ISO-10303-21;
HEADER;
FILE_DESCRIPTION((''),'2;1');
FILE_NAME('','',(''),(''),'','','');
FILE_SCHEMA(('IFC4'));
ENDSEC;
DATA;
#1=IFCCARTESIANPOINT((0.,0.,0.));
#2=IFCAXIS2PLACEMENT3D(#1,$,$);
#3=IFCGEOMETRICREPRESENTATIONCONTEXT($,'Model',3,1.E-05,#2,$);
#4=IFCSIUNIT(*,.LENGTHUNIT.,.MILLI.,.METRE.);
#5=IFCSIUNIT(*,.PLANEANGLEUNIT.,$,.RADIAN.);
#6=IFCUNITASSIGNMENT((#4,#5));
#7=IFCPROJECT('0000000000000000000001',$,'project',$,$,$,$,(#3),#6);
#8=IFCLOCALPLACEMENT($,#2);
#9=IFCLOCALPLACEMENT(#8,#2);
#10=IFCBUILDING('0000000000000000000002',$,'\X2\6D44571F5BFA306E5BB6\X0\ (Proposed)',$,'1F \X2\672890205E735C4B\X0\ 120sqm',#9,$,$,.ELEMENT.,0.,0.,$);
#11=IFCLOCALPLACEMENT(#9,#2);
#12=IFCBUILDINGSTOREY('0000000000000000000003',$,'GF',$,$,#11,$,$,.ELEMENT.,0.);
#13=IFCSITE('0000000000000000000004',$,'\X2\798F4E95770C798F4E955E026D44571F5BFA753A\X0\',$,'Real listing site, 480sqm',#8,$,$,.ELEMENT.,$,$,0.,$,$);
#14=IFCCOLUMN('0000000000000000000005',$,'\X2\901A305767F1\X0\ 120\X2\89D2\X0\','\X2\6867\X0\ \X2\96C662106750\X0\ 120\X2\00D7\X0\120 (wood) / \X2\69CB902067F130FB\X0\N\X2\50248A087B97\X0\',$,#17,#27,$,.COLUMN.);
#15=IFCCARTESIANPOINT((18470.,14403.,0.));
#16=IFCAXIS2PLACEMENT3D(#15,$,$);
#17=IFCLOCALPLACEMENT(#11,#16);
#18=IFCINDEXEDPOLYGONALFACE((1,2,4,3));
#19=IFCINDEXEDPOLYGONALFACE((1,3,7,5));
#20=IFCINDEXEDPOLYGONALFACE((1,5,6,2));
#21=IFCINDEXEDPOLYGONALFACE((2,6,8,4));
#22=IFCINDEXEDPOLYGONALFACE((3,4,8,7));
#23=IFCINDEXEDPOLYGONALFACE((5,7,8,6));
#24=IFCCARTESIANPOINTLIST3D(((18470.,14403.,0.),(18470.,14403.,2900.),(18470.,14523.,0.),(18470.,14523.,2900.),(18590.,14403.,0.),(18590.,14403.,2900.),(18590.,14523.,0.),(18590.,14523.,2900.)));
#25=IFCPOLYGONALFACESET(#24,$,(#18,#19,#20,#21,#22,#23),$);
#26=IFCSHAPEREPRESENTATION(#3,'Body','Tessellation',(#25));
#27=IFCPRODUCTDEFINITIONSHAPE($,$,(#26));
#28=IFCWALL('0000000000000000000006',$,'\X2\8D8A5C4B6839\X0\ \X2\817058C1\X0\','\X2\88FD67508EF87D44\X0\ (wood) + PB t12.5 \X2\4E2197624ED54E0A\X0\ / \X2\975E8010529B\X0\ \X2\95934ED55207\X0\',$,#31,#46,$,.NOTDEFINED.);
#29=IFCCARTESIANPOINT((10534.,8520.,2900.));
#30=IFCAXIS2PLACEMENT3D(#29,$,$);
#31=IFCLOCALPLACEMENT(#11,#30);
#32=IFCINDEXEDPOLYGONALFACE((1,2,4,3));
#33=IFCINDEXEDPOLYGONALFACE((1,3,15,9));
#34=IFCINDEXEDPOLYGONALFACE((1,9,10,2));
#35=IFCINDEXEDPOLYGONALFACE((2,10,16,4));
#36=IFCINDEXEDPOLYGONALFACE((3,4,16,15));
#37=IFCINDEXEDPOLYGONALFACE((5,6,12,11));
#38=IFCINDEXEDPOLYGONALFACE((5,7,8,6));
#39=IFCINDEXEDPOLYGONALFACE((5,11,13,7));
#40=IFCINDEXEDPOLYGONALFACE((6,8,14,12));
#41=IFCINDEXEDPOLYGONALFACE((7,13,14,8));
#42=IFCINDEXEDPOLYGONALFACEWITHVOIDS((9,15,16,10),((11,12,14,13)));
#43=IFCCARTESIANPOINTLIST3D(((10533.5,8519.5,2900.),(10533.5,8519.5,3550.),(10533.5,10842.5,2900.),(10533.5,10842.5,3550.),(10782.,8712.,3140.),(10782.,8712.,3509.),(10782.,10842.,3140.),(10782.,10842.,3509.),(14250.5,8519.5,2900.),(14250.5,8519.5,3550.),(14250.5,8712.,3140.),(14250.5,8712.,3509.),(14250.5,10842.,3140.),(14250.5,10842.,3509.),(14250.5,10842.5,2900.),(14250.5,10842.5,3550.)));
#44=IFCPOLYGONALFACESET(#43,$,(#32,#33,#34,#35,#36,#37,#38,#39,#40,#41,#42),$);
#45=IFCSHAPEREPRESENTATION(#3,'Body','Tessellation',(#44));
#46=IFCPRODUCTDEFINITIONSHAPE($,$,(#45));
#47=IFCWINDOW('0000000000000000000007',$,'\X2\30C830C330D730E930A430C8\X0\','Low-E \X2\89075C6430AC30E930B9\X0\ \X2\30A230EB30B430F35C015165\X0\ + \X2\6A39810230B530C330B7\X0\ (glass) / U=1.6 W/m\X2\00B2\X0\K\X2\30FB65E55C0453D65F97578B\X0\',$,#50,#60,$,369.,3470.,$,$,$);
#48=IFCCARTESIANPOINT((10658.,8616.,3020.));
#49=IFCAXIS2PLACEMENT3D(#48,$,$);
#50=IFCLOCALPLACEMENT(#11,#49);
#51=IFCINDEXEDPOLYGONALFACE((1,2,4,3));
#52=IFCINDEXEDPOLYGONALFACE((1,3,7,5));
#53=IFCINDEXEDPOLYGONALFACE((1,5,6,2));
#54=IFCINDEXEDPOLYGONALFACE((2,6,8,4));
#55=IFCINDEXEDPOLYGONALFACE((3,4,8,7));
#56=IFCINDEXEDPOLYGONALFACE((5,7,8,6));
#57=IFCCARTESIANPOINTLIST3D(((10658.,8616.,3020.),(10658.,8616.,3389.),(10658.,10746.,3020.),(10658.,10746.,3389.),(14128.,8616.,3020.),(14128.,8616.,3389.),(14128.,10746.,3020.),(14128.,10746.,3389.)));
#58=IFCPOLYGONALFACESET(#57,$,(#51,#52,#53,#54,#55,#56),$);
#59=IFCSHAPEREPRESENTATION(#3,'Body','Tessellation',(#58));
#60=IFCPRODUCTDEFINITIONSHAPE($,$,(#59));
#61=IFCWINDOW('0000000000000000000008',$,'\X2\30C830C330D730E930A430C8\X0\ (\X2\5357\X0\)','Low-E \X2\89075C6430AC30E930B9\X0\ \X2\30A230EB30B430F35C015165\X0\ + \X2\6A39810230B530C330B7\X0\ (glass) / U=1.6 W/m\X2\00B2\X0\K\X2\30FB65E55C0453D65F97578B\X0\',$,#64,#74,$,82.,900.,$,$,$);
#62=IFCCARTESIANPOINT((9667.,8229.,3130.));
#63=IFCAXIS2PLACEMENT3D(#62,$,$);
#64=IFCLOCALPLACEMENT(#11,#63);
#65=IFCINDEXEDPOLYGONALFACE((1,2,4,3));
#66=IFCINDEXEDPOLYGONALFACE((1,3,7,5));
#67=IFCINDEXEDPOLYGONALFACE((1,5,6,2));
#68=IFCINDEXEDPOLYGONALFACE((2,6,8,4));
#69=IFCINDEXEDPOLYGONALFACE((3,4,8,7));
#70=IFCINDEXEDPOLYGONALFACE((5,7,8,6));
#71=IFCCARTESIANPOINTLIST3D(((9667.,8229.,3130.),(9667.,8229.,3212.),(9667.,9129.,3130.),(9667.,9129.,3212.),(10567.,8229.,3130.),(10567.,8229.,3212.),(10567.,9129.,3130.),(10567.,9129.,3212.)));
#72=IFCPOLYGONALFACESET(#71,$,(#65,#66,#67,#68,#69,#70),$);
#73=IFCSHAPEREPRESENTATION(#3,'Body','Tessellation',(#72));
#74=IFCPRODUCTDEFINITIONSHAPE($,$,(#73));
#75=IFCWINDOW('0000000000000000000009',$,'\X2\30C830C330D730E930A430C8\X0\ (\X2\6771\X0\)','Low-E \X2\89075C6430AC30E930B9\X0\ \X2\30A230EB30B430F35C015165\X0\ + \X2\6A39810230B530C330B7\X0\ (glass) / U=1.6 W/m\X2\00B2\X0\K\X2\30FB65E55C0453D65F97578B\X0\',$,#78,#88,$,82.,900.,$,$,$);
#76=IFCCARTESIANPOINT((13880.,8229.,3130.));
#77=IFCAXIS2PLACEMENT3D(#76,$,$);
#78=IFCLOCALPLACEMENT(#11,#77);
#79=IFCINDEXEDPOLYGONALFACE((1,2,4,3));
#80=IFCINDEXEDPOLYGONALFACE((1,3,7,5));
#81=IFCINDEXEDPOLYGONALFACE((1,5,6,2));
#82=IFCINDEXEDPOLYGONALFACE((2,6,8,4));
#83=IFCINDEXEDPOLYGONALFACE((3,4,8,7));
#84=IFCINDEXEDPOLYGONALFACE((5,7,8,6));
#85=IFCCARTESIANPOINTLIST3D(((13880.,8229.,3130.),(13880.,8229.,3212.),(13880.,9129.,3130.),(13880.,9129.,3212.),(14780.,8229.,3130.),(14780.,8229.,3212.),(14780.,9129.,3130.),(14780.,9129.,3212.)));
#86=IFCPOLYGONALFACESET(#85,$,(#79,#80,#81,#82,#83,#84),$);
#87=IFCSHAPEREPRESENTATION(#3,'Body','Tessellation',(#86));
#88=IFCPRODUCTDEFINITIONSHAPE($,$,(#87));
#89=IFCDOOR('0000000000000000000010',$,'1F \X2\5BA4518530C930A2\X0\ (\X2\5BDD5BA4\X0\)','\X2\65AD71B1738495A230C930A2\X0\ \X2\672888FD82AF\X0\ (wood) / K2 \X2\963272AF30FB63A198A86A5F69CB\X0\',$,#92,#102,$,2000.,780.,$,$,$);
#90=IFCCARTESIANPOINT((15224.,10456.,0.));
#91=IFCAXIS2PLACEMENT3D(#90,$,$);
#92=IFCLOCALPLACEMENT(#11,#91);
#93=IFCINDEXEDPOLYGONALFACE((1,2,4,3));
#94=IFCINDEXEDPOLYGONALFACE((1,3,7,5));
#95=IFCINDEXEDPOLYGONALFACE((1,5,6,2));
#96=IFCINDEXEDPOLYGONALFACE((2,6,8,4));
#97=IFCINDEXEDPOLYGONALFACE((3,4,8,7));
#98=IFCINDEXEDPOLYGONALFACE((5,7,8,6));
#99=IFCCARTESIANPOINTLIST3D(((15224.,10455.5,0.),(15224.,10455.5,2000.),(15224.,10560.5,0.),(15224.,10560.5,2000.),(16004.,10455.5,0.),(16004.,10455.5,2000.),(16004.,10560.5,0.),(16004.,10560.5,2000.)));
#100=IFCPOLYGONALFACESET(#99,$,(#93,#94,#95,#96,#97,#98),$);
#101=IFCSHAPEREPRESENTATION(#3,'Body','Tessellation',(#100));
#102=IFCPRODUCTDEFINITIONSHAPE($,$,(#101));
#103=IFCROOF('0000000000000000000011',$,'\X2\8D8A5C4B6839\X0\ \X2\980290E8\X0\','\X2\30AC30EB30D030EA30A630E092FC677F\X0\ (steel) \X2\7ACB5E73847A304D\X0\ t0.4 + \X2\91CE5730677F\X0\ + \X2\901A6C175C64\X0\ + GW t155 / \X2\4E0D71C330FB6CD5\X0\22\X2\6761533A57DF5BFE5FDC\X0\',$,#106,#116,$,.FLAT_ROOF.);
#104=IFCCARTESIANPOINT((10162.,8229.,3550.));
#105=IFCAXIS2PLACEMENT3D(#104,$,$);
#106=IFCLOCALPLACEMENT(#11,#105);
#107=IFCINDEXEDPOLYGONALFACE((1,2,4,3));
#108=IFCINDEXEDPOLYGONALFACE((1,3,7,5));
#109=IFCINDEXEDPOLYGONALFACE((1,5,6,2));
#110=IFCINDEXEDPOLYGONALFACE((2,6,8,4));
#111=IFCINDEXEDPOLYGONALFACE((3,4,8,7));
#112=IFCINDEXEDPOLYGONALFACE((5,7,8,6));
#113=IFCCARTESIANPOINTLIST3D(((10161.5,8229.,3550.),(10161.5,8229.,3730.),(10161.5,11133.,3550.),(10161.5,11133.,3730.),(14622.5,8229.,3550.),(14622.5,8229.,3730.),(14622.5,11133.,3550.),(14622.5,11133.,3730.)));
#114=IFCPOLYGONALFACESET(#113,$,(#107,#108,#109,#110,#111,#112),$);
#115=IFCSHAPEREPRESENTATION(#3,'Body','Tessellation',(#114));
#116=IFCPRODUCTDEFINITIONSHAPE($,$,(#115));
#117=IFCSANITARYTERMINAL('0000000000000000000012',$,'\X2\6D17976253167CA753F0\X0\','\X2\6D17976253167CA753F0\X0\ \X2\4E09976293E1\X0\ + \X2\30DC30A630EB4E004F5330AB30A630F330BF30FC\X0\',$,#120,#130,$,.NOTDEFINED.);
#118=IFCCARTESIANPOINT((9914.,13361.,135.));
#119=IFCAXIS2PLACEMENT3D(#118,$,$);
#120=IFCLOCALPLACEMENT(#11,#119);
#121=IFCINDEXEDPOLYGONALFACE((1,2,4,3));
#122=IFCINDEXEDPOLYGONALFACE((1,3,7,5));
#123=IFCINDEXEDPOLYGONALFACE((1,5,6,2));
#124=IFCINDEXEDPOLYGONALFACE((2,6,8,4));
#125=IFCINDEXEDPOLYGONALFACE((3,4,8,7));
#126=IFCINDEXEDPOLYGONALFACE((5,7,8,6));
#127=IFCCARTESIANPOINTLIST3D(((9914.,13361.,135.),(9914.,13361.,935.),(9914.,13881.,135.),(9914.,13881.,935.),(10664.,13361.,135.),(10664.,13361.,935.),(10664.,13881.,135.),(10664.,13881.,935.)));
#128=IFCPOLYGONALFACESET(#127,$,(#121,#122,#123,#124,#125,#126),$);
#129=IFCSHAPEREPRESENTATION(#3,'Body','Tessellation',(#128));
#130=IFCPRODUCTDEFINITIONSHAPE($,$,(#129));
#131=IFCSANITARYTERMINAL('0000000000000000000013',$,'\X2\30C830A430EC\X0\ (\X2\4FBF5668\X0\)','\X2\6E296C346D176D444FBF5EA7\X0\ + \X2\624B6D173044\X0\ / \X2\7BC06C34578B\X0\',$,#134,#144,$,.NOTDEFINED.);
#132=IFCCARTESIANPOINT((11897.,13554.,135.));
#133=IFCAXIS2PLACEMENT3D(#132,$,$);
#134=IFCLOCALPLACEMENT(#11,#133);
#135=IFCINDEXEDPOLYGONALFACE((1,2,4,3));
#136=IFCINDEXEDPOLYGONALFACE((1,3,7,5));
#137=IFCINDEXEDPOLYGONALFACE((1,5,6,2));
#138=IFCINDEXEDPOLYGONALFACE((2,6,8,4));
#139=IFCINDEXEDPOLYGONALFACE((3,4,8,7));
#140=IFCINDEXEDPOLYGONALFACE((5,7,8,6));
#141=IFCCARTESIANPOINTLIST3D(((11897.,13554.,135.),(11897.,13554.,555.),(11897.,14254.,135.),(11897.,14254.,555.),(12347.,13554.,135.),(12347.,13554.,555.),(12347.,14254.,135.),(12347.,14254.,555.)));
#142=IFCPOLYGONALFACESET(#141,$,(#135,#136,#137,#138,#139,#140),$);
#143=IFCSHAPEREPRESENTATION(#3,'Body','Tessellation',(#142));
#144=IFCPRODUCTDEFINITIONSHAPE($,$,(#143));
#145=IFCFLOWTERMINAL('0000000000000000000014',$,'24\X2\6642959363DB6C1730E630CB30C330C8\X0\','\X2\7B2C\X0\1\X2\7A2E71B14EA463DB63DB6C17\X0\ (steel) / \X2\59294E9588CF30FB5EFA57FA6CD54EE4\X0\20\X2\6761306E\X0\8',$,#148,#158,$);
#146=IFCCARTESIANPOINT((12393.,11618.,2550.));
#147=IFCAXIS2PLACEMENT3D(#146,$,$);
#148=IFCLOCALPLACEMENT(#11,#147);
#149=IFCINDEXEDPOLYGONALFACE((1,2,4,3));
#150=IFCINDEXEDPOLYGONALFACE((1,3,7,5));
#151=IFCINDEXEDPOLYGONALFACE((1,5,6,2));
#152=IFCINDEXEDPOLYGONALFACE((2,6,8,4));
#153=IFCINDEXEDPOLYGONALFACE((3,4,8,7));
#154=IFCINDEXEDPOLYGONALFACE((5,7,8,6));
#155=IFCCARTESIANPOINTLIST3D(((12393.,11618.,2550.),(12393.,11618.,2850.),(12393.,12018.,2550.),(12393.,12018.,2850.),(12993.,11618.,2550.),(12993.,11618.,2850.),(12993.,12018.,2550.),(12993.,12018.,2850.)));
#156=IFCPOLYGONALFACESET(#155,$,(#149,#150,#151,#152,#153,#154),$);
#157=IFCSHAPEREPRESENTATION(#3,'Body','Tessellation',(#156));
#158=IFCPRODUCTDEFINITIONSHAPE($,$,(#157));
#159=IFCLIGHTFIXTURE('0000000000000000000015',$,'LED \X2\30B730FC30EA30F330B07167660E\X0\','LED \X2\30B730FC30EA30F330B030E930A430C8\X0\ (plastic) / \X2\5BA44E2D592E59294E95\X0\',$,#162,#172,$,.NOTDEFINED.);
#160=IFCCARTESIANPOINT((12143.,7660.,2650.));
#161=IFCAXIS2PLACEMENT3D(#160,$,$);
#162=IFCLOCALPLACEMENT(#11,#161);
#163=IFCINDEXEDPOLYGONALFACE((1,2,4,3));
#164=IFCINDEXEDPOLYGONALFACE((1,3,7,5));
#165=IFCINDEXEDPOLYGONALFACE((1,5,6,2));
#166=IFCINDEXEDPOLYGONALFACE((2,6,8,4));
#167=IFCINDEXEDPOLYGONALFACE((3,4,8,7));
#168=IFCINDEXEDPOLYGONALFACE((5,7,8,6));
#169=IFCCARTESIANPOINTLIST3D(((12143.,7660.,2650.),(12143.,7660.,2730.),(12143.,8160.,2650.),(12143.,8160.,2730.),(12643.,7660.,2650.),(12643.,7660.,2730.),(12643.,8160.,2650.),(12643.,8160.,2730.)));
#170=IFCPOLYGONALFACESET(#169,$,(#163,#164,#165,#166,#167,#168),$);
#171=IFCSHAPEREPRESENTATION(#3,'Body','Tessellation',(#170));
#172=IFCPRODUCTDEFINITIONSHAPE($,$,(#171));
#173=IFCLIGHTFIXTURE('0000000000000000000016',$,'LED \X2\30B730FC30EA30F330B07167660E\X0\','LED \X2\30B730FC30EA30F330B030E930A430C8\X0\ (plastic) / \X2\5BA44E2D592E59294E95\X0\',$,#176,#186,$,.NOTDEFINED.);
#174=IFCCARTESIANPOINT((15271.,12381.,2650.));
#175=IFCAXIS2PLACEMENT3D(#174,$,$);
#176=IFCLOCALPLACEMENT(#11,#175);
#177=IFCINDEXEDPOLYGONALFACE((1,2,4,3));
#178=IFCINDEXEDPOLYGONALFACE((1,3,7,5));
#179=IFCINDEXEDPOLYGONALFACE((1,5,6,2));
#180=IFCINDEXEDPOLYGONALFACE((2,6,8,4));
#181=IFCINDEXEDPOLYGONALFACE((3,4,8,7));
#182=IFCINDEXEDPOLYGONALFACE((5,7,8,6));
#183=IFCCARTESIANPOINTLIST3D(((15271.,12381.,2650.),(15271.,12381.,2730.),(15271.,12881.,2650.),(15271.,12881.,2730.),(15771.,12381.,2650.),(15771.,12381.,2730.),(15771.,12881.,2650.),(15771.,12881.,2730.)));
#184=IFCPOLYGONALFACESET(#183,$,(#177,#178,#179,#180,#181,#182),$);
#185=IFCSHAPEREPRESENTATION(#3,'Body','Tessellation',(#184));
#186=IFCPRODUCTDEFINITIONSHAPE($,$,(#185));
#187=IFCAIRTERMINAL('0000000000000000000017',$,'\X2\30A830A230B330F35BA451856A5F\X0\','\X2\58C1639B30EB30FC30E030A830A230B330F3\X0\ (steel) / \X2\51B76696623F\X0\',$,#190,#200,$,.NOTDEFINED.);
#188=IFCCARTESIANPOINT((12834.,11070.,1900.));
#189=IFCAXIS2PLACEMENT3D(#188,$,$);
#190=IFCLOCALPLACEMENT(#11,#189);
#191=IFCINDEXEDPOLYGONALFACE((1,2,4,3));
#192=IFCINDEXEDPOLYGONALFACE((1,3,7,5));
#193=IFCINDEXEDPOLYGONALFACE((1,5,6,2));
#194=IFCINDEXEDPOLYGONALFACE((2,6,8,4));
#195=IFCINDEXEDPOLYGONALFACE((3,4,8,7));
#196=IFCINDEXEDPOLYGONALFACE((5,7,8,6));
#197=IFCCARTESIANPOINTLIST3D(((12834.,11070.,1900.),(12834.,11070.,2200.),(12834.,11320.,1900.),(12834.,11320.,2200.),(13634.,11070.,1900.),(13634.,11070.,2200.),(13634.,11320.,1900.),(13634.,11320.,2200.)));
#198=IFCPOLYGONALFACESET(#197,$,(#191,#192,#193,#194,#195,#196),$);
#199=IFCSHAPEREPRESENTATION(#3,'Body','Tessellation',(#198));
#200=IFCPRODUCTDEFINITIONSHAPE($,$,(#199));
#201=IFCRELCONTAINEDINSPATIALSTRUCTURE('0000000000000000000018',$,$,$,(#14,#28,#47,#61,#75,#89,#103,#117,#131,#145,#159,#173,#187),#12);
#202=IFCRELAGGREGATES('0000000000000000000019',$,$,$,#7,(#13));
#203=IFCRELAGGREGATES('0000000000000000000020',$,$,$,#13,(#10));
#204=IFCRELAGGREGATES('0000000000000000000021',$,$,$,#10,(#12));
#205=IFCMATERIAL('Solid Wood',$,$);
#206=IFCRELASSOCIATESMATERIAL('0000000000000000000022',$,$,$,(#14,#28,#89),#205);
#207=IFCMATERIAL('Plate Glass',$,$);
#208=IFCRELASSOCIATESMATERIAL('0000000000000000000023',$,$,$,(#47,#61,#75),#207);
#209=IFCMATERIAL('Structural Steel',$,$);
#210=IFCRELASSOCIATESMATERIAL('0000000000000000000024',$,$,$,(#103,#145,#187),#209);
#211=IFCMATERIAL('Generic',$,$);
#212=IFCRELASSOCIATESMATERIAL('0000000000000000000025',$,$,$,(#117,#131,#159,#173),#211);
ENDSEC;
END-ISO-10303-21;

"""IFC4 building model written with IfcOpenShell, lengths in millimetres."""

from ifc_helpers import new_model, si_unit, frame, frame_2d, origin, place, context, project, spatial, rectangle, extrude, material, element, fill, save


model = new_model("IFC4")

# Units and contexts
model_context = context("Model", 3, precision=1e-05, world=origin())
ifc_project = project(units=[si_unit("LENGTHUNIT", "METRE", prefix="MILLI"), si_unit("PLANEANGLEUNIT", "RADIAN")], contexts=[model_context])

# Site, building, storey
site_placement = place(None, origin())
site = spatial("IfcSite", under=ifc_project, at=site_placement, Name="福井県福井市浄土寺町", ObjectType="Real listing site, 480sqm", CompositionType="ELEMENT", RefElevation=0.0)
building_placement = place(site_placement, origin())
building = spatial("IfcBuilding", under=site, at=building_placement, Name="浄土寺の家 (Proposed)", ObjectType="1F 木造平屋 120sqm", CompositionType="ELEMENT", ElevationOfRefHeight=0.0, ElevationOfTerrain=0.0)
storey_placement = place(building_placement, origin())
storey = spatial("IfcBuildingStorey", under=building, at=storey_placement, Name="GF", CompositionType="ELEMENT", Elevation=0.0)

# Column
ifc_material_1 = material(Name="Solid Wood")
column_1_placement = place(storey_placement, frame((18470.0, 14403.0, 0.0)))
element("IfcColumn", 1, at=column_1_placement, inside=storey, material=ifc_material_1, Name="通し柱 120角", Description="桧 集成材 120×120 (wood) / 構造柱・N値計算", PredefinedType="COLUMN", context=model_context, shape_type="SweptSolid", body=[
    extrude(rectangle(XDim=120.0, YDim=120.0, at=frame_2d((60.0, 60.0))), frame((18470.0, 14403.0, 0.0)), (0.0, 0.0, 1.0), 2900.0),
])

# Wall, openings, windows
wall_1_placement = place(storey_placement, frame((10534.0, 8520.0, 2900.0)))
wall_1 = element("IfcWall", 2, at=wall_1_placement, inside=storey, material=ifc_material_1, Name="越屋根 腰壁", Description="製材軸組 (wood) + PB t12.5 両面仕上 / 非耐力 間仕切", PredefinedType="NOTDEFINED", context=model_context, shape_type="SweptSolid", body=[
    extrude(rectangle(XDim=3717.0, YDim=2323.0, at=frame_2d((1858.0, 1161.0))), frame((10534.0, 8520.0, 2900.0)), (0.0, 0.0, 1.0), 650.0),
])
opening_1_placement = place(storey_placement, frame((10658.0, 8616.0, 3020.0)))
opening_1 = element("IfcOpeningElement", 3, at=opening_1_placement, cuts=wall_1, PredefinedType="NOTDEFINED", context=model_context, shape_type="SweptSolid", body=[
    extrude(rectangle(XDim=3470.0, YDim=2130.0, at=frame_2d((1735.0, 1065.0))), frame((10658.0, 8616.0, 3020.0)), (0.0, 0.0, 1.0), 369.0),
])
opening_2_placement = place(storey_placement, frame((9667.0, 8229.0, 3130.0)))
opening_2 = element("IfcOpeningElement", 4, at=opening_2_placement, cuts=wall_1, PredefinedType="NOTDEFINED", context=model_context, shape_type="SweptSolid", body=[
    extrude(rectangle(XDim=900.0, YDim=900.0, at=frame_2d((450.0, 450.0))), frame((9667.0, 8229.0, 3130.0)), (0.0, 0.0, 1.0), 82.0),
])
opening_3_placement = place(storey_placement, frame((13880.0, 8229.0, 3130.0)))
opening_3 = element("IfcOpeningElement", 5, at=opening_3_placement, cuts=wall_1, PredefinedType="NOTDEFINED", context=model_context, shape_type="SweptSolid", body=[
    extrude(rectangle(XDim=900.0, YDim=900.0, at=frame_2d((450.0, 450.0))), frame((13880.0, 8229.0, 3130.0)), (0.0, 0.0, 1.0), 82.0),
])
ifc_material_2 = material(Name="Plate Glass")
window_1_placement = place(storey_placement, frame((10658.0, 8616.0, 3020.0)))
window_1 = element("IfcWindow", 6, at=window_1_placement, inside=storey, material=ifc_material_2, Name="トップライト", Description="Low-E 複層ガラス アルゴン封入 + 樹脂サッシ (glass) / U=1.6 W/m²K・日射取得型", OverallHeight=369.0, OverallWidth=3470.0, context=model_context, shape_type="SweptSolid", body=[
    extrude(rectangle(XDim=3470.0, YDim=2130.0, at=frame_2d((1735.0, 1065.0))), frame((10658.0, 8616.0, 3020.0)), (0.0, 0.0, 1.0), 369.0),
])
fill(opening_1, window_1)
window_2_placement = place(storey_placement, frame((9667.0, 8229.0, 3130.0)))
window_2 = element("IfcWindow", 7, at=window_2_placement, inside=storey, material=ifc_material_2, Name="トップライト (南)", Description="Low-E 複層ガラス アルゴン封入 + 樹脂サッシ (glass) / U=1.6 W/m²K・日射取得型", OverallHeight=82.0, OverallWidth=900.0, context=model_context, shape_type="SweptSolid", body=[
    extrude(rectangle(XDim=900.0, YDim=900.0, at=frame_2d((450.0, 450.0))), frame((9667.0, 8229.0, 3130.0)), (0.0, 0.0, 1.0), 82.0),
])
fill(opening_2, window_2)
window_3_placement = place(storey_placement, frame((13880.0, 8229.0, 3130.0)))
window_3 = element("IfcWindow", 8, at=window_3_placement, inside=storey, material=ifc_material_2, Name="トップライト (東)", Description="Low-E 複層ガラス アルゴン封入 + 樹脂サッシ (glass) / U=1.6 W/m²K・日射取得型", OverallHeight=82.0, OverallWidth=900.0, context=model_context, shape_type="SweptSolid", body=[
    extrude(rectangle(XDim=900.0, YDim=900.0, at=frame_2d((450.0, 450.0))), frame((13880.0, 8229.0, 3130.0)), (0.0, 0.0, 1.0), 82.0),
])
fill(opening_3, window_3)

# Door
door_placement = place(storey_placement, frame((15224.0, 10456.0, 0.0)))
element("IfcDoor", 9, at=door_placement, inside=storey, material=ifc_material_1, Name="1F 室内ドア (寝室)", Description="断熱玄関ドア 木製芯 (wood) / K2 防犯・採風機構", OverallHeight=2000.0, OverallWidth=780.0, context=model_context, shape_type="SweptSolid", body=[
    extrude(rectangle(XDim=780.0, YDim=105.0, at=frame_2d((390.0, 52.0))), frame((15224.0, 10456.0, 0.0)), (0.0, 0.0, 1.0), 2000.0),
])

# Roof
ifc_material_3 = material(Name="Structural Steel")
roof_placement = place(storey_placement, frame((10162.0, 8229.0, 3550.0)))
element("IfcRoof", 10, at=roof_placement, inside=storey, material=ifc_material_3, Name="越屋根 頂部", Description="ガルバリウム鋼板 (steel) 立平葺き t0.4 + 野地板 + 通気層 + GW t155 / 不燃・法22条区域対応", PredefinedType="FLAT_ROOF", context=model_context, shape_type="SweptSolid", body=[
    extrude(rectangle(XDim=4461.0, YDim=2904.0, at=frame_2d((2230.0, 1452.0))), frame((10162.0, 8229.0, 3550.0)), (0.0, 0.0, 1.0), 180.0),
])

# Sanitary terminals
ifc_material_4 = material(Name="Generic")
sanitary_terminal_1_placement = place(storey_placement, frame((9914.0, 13361.0, 135.0)))
element("IfcSanitaryTerminal", 11, at=sanitary_terminal_1_placement, inside=storey, material=ifc_material_4, Name="洗面化粧台", Description="洗面化粧台 三面鏡 + ボウル一体カウンター", PredefinedType="NOTDEFINED", context=model_context, shape_type="SweptSolid", body=[
    extrude(rectangle(XDim=750.0, YDim=520.0, at=frame_2d((375.0, 260.0))), frame((9914.0, 13361.0, 135.0)), (0.0, 0.0, 1.0), 800.0),
])
sanitary_terminal_2_placement = place(storey_placement, frame((11897.0, 13554.0, 135.0)))
element("IfcSanitaryTerminal", 12, at=sanitary_terminal_2_placement, inside=storey, material=ifc_material_4, Name="トイレ (便器)", Description="温水洗浄便座 + 手洗い / 節水型", PredefinedType="NOTDEFINED", context=model_context, shape_type="SweptSolid", body=[
    extrude(rectangle(XDim=450.0, YDim=700.0, at=frame_2d((225.0, 350.0))), frame((11897.0, 13554.0, 135.0)), (0.0, 0.0, 1.0), 420.0),
])

# Flow terminal
flow_terminal_placement = place(storey_placement, frame((12393.0, 11618.0, 2550.0)))
element("IfcFlowTerminal", 13, at=flow_terminal_placement, inside=storey, material=ifc_material_3, Name="24時間換気ユニット", Description="第1種熱交換換気 (steel) / 天井裏・建基法令20条の8", context=model_context, shape_type="SweptSolid", body=[
    extrude(rectangle(XDim=600.0, YDim=400.0, at=frame_2d((300.0, 200.0))), frame((12393.0, 11618.0, 2550.0)), (0.0, 0.0, 1.0), 300.0),
])

# Light fixtures
light_fixture_1_placement = place(storey_placement, frame((12143.0, 7660.0, 2650.0)))
element("IfcLightFixture", 14, at=light_fixture_1_placement, inside=storey, material=ifc_material_4, Name="LED シーリング照明", Description="LED シーリングライト (plastic) / 室中央天井", PredefinedType="NOTDEFINED", context=model_context, shape_type="SweptSolid", body=[
    extrude(rectangle(XDim=500.0, YDim=500.0, at=frame_2d((250.0, 250.0))), frame((12143.0, 7660.0, 2650.0)), (0.0, 0.0, 1.0), 80.0),
])
light_fixture_2_placement = place(storey_placement, frame((15271.0, 12381.0, 2650.0)))
element("IfcLightFixture", 15, at=light_fixture_2_placement, inside=storey, material=ifc_material_4, Name="LED シーリング照明", Description="LED シーリングライト (plastic) / 室中央天井", PredefinedType="NOTDEFINED", context=model_context, shape_type="SweptSolid", body=[
    extrude(rectangle(XDim=500.0, YDim=500.0, at=frame_2d((250.0, 250.0))), frame((15271.0, 12381.0, 2650.0)), (0.0, 0.0, 1.0), 80.0),
])

# Air terminal
air_terminal_placement = place(storey_placement, frame((12834.0, 11070.0, 1900.0)))
element("IfcAirTerminal", 16, at=air_terminal_placement, inside=storey, material=ifc_material_3, Name="エアコン室内機", Description="壁掛ルームエアコン (steel) / 冷暖房", PredefinedType="NOTDEFINED", context=model_context, shape_type="SweptSolid", body=[
    extrude(rectangle(XDim=800.0, YDim=250.0, at=frame_2d((400.0, 125.0))), frame((12834.0, 11070.0, 1900.0)), (0.0, 0.0, 1.0), 300.0),
])

save(model, "model.ifc")
